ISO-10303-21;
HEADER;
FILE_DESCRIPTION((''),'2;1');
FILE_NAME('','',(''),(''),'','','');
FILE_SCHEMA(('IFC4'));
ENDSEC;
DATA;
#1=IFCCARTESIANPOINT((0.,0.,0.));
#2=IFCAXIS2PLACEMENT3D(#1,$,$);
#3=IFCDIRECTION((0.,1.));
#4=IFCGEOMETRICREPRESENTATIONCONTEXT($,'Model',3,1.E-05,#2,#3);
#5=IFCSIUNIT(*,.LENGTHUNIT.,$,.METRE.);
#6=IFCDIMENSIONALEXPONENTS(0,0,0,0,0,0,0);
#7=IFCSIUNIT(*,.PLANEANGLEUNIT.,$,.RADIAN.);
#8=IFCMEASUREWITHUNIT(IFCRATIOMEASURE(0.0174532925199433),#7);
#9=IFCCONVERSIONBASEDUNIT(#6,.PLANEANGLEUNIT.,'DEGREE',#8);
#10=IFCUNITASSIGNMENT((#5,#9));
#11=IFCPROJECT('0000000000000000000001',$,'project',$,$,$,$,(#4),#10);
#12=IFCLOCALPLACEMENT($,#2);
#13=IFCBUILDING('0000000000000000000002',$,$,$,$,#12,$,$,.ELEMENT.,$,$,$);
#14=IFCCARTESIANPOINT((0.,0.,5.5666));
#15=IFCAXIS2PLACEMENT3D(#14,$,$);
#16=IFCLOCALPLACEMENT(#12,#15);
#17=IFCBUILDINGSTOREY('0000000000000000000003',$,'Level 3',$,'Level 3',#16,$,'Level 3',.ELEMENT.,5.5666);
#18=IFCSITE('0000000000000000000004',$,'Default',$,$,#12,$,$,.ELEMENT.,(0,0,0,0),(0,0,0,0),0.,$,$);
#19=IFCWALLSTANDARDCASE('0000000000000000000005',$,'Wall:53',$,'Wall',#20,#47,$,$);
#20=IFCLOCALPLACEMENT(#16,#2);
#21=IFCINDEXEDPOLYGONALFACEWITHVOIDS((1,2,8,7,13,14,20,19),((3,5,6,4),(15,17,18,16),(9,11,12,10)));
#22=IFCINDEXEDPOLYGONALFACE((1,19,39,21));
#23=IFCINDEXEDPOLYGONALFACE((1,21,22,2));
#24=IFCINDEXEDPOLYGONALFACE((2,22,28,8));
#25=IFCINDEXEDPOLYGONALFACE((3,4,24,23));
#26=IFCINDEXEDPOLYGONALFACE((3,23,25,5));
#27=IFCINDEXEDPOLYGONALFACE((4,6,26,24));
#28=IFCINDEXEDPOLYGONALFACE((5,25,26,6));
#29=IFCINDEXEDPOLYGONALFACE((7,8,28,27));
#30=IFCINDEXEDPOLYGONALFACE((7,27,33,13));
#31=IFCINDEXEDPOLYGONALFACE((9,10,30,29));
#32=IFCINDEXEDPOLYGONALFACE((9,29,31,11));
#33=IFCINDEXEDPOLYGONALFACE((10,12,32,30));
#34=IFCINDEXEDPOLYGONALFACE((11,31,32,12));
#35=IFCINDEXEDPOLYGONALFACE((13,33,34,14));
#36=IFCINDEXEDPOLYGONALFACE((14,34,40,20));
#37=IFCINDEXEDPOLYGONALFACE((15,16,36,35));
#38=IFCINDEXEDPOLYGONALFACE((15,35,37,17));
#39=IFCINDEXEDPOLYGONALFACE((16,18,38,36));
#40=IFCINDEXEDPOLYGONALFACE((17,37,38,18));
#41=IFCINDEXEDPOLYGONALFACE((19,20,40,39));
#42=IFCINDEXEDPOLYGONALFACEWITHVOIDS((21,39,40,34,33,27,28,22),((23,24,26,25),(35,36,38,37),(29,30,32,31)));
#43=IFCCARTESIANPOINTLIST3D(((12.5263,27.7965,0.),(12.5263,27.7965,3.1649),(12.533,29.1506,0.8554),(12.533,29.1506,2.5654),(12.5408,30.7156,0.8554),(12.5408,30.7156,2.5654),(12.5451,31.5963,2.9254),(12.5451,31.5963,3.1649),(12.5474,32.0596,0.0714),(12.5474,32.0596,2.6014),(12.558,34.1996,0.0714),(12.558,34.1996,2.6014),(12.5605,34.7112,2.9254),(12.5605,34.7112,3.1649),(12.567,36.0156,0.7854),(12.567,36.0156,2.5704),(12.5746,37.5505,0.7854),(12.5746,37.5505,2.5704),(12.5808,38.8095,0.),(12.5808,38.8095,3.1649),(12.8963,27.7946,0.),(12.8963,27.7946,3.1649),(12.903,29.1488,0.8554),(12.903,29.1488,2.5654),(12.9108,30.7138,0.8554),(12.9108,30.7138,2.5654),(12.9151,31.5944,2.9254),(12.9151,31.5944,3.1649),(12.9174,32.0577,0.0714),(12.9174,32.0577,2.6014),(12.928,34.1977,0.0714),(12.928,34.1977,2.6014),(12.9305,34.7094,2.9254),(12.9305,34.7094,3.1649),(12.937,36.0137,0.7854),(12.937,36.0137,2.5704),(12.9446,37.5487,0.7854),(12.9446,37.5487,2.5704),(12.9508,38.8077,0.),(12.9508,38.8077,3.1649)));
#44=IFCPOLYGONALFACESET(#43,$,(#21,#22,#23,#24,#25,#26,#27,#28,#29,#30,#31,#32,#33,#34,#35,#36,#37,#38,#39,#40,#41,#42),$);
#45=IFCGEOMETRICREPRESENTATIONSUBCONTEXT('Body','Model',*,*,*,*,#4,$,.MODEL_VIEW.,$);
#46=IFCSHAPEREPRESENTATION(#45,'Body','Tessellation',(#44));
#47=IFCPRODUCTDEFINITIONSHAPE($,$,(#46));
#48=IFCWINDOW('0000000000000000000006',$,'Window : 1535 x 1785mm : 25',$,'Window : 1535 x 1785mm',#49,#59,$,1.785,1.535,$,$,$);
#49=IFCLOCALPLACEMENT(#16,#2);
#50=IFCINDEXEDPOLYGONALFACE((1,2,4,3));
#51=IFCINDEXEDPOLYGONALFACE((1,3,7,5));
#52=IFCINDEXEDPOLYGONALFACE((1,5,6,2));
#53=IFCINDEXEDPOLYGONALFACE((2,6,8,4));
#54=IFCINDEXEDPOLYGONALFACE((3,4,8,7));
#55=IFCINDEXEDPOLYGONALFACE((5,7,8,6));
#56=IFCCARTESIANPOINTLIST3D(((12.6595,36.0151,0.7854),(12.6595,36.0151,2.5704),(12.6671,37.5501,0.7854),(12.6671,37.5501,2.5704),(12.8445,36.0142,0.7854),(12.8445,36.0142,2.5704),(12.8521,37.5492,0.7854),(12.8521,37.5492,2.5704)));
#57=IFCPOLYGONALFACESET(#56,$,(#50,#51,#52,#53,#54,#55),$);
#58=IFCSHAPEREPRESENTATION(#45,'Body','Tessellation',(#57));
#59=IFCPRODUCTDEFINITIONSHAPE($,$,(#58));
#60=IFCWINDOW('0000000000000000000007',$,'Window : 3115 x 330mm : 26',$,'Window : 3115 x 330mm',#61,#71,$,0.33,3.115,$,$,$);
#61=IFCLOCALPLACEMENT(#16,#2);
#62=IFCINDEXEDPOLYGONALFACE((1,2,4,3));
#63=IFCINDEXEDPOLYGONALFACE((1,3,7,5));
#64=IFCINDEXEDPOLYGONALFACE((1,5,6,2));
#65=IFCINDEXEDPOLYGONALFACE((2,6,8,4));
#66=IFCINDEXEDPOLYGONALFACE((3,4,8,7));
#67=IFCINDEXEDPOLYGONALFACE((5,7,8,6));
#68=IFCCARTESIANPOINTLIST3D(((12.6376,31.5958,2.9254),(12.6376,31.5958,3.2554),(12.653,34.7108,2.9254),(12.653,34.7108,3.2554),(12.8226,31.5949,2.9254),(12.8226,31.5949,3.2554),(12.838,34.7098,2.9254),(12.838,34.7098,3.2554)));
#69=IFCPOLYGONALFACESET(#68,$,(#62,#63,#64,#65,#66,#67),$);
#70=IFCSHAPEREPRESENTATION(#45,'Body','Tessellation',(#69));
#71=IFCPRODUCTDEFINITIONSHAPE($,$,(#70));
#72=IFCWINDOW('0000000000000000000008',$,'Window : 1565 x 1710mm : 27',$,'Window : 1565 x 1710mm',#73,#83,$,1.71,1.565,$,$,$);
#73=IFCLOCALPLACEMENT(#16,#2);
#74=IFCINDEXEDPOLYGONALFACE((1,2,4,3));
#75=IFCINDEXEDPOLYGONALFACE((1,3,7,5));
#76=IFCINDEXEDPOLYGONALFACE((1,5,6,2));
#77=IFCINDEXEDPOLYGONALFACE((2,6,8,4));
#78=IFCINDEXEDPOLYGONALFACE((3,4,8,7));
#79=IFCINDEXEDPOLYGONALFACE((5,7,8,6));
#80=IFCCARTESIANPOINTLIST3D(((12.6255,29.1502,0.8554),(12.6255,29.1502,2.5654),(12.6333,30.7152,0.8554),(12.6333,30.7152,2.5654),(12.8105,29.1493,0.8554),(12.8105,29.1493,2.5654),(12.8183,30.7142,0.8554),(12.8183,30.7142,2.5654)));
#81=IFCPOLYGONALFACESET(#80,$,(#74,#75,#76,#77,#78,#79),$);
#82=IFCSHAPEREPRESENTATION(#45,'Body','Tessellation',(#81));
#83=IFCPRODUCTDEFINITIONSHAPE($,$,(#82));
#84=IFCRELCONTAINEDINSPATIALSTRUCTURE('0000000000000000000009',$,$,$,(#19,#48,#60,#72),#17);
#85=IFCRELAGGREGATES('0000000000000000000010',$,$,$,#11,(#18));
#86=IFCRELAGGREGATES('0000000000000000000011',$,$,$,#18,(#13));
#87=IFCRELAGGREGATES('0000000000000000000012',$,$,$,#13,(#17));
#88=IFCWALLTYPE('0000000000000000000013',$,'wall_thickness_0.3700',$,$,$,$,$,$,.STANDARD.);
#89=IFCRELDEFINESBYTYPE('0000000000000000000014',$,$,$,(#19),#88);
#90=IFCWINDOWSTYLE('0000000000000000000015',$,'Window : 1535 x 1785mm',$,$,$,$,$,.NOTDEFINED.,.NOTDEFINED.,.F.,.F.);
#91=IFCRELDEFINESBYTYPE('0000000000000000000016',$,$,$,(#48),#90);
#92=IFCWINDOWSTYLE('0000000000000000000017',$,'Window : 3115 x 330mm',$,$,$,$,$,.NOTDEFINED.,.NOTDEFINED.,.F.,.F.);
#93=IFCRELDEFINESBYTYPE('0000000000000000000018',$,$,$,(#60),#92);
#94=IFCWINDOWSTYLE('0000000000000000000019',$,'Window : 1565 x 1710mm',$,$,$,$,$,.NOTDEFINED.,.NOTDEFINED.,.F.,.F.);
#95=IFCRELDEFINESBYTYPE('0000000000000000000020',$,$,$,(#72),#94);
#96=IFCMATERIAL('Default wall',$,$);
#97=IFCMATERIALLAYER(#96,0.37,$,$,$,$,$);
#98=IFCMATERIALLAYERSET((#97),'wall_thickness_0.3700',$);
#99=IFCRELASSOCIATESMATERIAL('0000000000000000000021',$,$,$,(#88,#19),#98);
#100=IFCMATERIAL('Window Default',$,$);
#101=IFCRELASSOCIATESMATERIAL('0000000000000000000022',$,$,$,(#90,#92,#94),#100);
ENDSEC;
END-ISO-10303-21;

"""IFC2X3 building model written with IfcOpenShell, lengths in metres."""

from ifc_helpers import new_model, entity, si_unit, converted_unit, direction, frame, frame_2d, origin, origin_2d_with_axis, place, context, subcontext, project, spatial, polyline, rectangle, outline, extrude, source, transform, mapped, material, layer, layer_set, layer_usage, type_object, type_shapes, element, fill, save


model = new_model("IFC2X3")

# Units and contexts
model_context = context("Model", 3, precision=1e-05, world=origin(), true_north=direction((0.0, 1.0)))
body_context = subcontext(model_context, "Body", "Model", "MODEL_VIEW")
ifc_project = project(units=[si_unit("LENGTHUNIT", "METRE"), converted_unit("PLANEANGLEUNIT", "DEGREE", entity("IfcRatioMeasure", 0.0174532925199433), si_unit("PLANEANGLEUNIT", "RADIAN"), dimensions=[0, 0, 0, 0, 0, 0, 0])], contexts=[model_context])

# Site, building, storey
placement = place(None, origin())
site = spatial("IfcSite", under=ifc_project, at=placement, Name="Default", CompositionType="ELEMENT", RefLatitude=(0, 0, 0, 0), RefLongitude=(0, 0, 0, 0), RefElevation=0.0)
building = spatial("IfcBuilding", under=site, at=placement, CompositionType="ELEMENT")
storey_placement = place(placement, frame((0.0, 0.0, 5.5666)))
storey = spatial("IfcBuildingStorey", under=building, at=storey_placement, Name="Level 3", ObjectType="Level 3", LongName="Level 3", CompositionType="ELEMENT", Elevation=5.5666)

# Shared definitions
ifc_material_1 = material(Name="Default wall")
ifc_material_2 = material(Name="Window Default")

# Shared definitions
ifc_layer_1 = layer(ifc_material_1, 0.37)
ifc_layer_set_1 = layer_set([ifc_layer_1], Name="wall_thickness_0.3700")
ifc_layer_usage_1 = layer_usage(ifc_layer_set_1, "AXIS2", "POSITIVE", -0.185)
wall_type_1 = type_object("IfcWallType", Name="wall_thickness_0.3700", PredefinedType="STANDARD", material=ifc_layer_set_1)

# Wall, openings, windows
wall_1_placement = place(storey_placement, frame((12.7658, 38.8086, 0.0), z_axis=(0.0, 0.0, 1.0), x_axis=(-0.004948, -0.999988, 0.0)))
wall_1 = element("IfcWallStandardCase", 1, at=wall_1_placement, inside=storey, type_object=wall_type_1, material=ifc_layer_usage_1, Name="Wall:53", ObjectType="Wall", context=body_context, shape_type="SweptSolid", body=[
    extrude(outline(polyline([(11.0132, -0.185), (11.0132, 0.185), (0.0, 0.185), (0.0, -0.185), (11.0132, -0.185)])), origin(), (0.0, 0.0, 1.0), 3.1649),
])
opening_1_placement = place(wall_1_placement, frame((4.61, -0.185, 0.0714)))
element("IfcOpeningElement", 2, at=opening_1_placement, cuts=wall_1, ObjectType="Opening", context=body_context, shape_type="SweptSolid", body=[
    extrude(rectangle(XDim=2.14, YDim=2.53, at=frame_2d((1.265, 1.07), x_axis=(0.0, 1.0))), frame((0.0, 0.0, 0.0), z_axis=(0.0, 1.0, 0.0), x_axis=(0.0, 0.0, 1.0)), (0.0, 0.0, 1.0), 0.37),
])
opening_2_placement = place(wall_1_placement, frame((1.259, -0.185, 0.7854)))
opening_2 = element("IfcOpeningElement", 3, at=opening_2_placement, cuts=wall_1, ObjectType="Opening", context=body_context, shape_type="SweptSolid", body=[
    extrude(rectangle(XDim=1.535, YDim=1.785, at=frame_2d((0.8925, 0.7675), x_axis=(0.0, 1.0))), frame((0.0, 0.0, 0.0), z_axis=(0.0, 1.0, 0.0), x_axis=(0.0, 0.0, 1.0)), (0.0, 0.0, 1.0), 0.37),
])
opening_3_placement = place(wall_1_placement, frame((4.0984, -0.185, 2.9254)))
opening_3 = element("IfcOpeningElement", 4, at=opening_3_placement, cuts=wall_1, ObjectType="Opening", context=body_context, shape_type="SweptSolid", body=[
    extrude(rectangle(XDim=3.115, YDim=0.33, at=frame_2d((0.165, 1.5575), x_axis=(0.0, 1.0))), frame((0.0, 0.0, 0.0), z_axis=(0.0, 1.0, 0.0), x_axis=(0.0, 0.0, 1.0)), (0.0, 0.0, 1.0), 0.37),
])
opening_4_placement = place(wall_1_placement, frame((8.094, -0.185, 0.8554)))
opening_4 = element("IfcOpeningElement", 5, at=opening_4_placement, cuts=wall_1, ObjectType="Opening", context=body_context, shape_type="SweptSolid", body=[
    extrude(rectangle(XDim=1.565, YDim=1.71, at=frame_2d((0.855, 0.7825), x_axis=(0.0, 1.0))), frame((0.0, 0.0, 0.0), z_axis=(0.0, 1.0, 0.0), x_axis=(0.0, 0.0, 1.0)), (0.0, 0.0, 1.0), 0.37),
])
window_style_1 = type_object("IfcWindowStyle", Name="Window : 1535 x 1785mm", ConstructionType="NOTDEFINED", OperationType="NOTDEFINED", ParameterTakesPrecedence=False, Sizeable=False, material=ifc_material_2)
shared_shape_1 = source(origin(), body_context, "Body", "SweptSolid", [
    extrude(rectangle(XDim=0.185, YDim=1.535, at=origin_2d_with_axis()), frame((0.7675, 0.185, 0.0), z_axis=(0.0, 0.0, 1.0), x_axis=(0.0, 1.0, 0.0)), (0.0, 0.0, 1.0), 1.785),
])
type_shapes(window_style_1, [shared_shape_1])
window_1_placement = place(opening_2_placement, origin())
window_1 = element("IfcWindow", 6, at=window_1_placement, inside=storey, type_object=window_style_1, Name="Window : 1535 x 1785mm : 25", ObjectType="Window : 1535 x 1785mm", OverallHeight=1.785, OverallWidth=1.535, context=body_context, shape_type="MappedRepresentation", body=[
    mapped(shared_shape_1, transform((0.0, 0.0, 0.0), scale=1.0)),
])
fill(opening_2, window_1)
window_style_2 = type_object("IfcWindowStyle", Name="Window : 3115 x 330mm", ConstructionType="NOTDEFINED", OperationType="NOTDEFINED", ParameterTakesPrecedence=False, Sizeable=False, material=ifc_material_2)
shared_shape_2 = source(origin(), body_context, "Body", "SweptSolid", [
    extrude(rectangle(XDim=0.185, YDim=3.115, at=origin_2d_with_axis()), frame((1.5575, 0.185, 0.0), z_axis=(0.0, 0.0, 1.0), x_axis=(0.0, 1.0, 0.0)), (0.0, 0.0, 1.0), 0.33),
])
type_shapes(window_style_2, [shared_shape_2])
window_2_placement = place(opening_3_placement, origin())
window_2 = element("IfcWindow", 7, at=window_2_placement, inside=storey, type_object=window_style_2, Name="Window : 3115 x 330mm : 26", ObjectType="Window : 3115 x 330mm", OverallHeight=0.33, OverallWidth=3.115, context=body_context, shape_type="MappedRepresentation", body=[
    mapped(shared_shape_2, transform((0.0, 0.0, 0.0), scale=1.0)),
])
fill(opening_3, window_2)
window_style_3 = type_object("IfcWindowStyle", Name="Window : 1565 x 1710mm", ConstructionType="NOTDEFINED", OperationType="NOTDEFINED", ParameterTakesPrecedence=False, Sizeable=False, material=ifc_material_2)
shared_shape_3 = source(origin(), body_context, "Body", "SweptSolid", [
    extrude(rectangle(XDim=0.185, YDim=1.565, at=origin_2d_with_axis()), frame((0.7825, 0.185, 0.0), z_axis=(0.0, 0.0, 1.0), x_axis=(0.0, 1.0, 0.0)), (0.0, 0.0, 1.0), 1.71),
])
type_shapes(window_style_3, [shared_shape_3])
window_3_placement = place(opening_4_placement, origin())
window_3 = element("IfcWindow", 8, at=window_3_placement, inside=storey, type_object=window_style_3, Name="Window : 1565 x 1710mm : 27", ObjectType="Window : 1565 x 1710mm", OverallHeight=1.71, OverallWidth=1.565, context=body_context, shape_type="MappedRepresentation", body=[
    mapped(shared_shape_3, transform((0.0, 0.0, 0.0), scale=1.0)),
])
fill(opening_4, window_3)

save(model, "model.ifc")
